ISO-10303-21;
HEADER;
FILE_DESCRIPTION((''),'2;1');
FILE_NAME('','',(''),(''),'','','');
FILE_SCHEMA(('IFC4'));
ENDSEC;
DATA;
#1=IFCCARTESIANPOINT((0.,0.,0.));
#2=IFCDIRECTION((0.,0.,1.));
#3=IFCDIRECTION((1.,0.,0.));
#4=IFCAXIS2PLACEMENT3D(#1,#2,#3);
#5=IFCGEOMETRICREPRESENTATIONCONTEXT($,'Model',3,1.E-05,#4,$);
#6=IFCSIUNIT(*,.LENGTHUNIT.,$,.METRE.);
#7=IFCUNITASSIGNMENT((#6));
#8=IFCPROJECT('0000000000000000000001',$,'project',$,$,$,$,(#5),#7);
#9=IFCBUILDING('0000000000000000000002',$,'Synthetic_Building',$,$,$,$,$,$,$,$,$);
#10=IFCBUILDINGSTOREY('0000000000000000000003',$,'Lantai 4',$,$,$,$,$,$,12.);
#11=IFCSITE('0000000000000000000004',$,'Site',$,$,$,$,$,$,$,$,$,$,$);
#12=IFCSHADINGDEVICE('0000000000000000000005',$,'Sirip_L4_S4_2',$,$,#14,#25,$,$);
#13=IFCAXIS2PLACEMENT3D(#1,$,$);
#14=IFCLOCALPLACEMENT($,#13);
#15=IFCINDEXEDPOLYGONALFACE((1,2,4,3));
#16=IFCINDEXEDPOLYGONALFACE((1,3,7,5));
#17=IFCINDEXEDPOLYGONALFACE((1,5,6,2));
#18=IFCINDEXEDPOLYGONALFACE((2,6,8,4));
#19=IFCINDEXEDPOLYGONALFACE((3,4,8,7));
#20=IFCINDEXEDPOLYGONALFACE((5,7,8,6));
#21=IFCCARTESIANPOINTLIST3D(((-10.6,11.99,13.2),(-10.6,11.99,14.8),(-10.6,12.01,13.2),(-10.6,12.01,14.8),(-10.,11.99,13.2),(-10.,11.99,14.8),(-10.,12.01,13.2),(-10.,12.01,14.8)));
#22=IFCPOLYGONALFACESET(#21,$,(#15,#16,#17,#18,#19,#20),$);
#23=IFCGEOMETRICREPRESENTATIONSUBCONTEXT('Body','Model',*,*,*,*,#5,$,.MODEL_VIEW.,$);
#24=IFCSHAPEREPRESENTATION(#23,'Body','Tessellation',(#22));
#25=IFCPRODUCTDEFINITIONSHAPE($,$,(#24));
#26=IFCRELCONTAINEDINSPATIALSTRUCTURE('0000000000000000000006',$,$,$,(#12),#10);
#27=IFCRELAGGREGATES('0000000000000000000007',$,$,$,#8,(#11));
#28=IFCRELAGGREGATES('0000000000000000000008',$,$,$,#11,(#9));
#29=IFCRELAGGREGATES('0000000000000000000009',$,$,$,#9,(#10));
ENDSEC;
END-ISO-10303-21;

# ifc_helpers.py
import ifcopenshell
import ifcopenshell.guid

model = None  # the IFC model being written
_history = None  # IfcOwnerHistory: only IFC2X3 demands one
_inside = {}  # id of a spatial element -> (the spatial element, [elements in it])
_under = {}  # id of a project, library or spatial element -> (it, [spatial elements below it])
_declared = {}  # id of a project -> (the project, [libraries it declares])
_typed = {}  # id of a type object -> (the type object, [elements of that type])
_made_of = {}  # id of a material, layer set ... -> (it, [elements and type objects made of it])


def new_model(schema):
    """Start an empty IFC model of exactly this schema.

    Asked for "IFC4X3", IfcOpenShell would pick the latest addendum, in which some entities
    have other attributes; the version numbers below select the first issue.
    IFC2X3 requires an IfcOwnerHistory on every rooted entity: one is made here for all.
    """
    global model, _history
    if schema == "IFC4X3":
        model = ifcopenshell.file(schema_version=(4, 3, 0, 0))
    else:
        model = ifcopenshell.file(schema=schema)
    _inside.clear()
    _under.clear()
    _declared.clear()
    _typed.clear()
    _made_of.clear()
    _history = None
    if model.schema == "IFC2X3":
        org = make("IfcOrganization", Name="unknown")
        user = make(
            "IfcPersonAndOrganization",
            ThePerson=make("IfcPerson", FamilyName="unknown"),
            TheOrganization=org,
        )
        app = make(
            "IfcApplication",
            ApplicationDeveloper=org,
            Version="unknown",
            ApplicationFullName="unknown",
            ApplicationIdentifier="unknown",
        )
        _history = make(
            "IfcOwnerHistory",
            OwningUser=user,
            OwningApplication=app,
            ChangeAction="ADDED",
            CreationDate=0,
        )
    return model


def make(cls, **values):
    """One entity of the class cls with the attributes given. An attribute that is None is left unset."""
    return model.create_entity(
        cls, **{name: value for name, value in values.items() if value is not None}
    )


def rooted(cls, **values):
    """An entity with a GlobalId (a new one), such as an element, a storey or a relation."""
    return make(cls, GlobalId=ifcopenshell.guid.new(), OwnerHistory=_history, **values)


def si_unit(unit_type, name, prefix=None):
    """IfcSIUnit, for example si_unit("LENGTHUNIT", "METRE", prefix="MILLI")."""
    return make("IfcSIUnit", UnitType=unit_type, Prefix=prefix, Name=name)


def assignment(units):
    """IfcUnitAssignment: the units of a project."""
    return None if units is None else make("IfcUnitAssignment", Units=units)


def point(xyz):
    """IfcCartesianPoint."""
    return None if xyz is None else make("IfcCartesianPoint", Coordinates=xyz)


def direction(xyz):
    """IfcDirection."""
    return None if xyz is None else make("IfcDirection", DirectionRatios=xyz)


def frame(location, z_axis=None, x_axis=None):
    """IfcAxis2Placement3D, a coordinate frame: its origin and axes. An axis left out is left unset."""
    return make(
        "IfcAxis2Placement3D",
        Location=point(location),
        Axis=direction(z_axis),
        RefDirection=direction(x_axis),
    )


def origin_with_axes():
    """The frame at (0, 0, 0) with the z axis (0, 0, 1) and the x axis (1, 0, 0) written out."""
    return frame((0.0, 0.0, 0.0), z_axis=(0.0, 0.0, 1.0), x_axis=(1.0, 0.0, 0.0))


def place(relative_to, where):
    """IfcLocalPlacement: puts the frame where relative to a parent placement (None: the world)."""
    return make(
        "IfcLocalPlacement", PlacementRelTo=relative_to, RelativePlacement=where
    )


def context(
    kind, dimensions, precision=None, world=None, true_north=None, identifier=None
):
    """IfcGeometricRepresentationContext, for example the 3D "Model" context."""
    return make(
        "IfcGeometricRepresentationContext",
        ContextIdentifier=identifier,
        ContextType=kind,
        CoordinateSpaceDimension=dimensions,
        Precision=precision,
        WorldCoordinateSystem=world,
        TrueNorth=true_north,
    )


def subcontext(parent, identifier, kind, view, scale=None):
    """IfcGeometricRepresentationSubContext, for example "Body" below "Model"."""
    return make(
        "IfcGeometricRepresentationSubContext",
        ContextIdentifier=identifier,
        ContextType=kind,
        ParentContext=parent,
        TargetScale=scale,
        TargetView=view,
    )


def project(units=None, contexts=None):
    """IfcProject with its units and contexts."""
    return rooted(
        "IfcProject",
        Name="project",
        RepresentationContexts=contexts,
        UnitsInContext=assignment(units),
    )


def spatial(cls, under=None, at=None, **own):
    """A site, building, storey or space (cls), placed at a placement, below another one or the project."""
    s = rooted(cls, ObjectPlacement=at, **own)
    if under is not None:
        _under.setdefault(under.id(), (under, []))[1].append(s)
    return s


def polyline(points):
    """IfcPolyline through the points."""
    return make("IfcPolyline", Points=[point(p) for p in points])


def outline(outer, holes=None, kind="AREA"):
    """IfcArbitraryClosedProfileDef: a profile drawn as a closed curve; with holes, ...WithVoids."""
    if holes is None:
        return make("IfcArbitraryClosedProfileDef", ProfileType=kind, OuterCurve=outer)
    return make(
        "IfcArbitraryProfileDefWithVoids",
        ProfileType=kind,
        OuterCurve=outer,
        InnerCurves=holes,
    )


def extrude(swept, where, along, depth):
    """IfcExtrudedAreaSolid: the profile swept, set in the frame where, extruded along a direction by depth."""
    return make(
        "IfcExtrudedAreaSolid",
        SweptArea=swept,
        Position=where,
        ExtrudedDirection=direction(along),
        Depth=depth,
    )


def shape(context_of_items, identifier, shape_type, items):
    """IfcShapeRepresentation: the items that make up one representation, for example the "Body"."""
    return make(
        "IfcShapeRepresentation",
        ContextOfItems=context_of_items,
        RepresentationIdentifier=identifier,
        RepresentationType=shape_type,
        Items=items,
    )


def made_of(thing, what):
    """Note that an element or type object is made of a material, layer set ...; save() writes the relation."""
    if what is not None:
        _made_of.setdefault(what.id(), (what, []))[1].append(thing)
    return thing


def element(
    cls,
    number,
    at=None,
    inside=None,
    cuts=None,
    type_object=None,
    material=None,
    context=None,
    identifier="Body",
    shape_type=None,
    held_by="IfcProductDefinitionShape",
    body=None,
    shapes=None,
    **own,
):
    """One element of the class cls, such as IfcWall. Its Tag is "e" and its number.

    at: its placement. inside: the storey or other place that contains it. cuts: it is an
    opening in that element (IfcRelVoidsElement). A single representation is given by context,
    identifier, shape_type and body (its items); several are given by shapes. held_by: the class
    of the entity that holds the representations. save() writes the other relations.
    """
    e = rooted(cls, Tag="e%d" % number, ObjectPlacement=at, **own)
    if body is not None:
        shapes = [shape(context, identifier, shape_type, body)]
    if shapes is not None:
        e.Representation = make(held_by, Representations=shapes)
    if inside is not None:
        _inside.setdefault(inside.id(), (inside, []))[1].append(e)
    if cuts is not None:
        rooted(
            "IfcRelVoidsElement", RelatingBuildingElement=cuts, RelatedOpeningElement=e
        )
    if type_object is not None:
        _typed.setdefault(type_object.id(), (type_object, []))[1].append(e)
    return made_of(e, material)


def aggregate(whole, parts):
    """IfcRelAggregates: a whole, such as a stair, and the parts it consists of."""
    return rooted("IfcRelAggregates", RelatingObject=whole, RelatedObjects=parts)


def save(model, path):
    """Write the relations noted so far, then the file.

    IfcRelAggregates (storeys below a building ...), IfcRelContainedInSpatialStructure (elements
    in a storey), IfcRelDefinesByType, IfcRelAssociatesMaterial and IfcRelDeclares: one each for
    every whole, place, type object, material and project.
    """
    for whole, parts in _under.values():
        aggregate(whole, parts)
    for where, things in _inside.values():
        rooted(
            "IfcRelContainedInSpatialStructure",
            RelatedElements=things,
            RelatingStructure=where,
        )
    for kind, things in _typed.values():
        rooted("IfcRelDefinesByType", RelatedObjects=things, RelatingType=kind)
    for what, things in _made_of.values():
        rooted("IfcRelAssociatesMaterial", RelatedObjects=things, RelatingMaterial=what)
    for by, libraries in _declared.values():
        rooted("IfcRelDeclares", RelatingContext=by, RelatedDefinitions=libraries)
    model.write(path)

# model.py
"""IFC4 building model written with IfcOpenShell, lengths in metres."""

from ifc_helpers import new_model, si_unit, frame, origin_with_axes, place, context, subcontext, project, spatial, polyline, outline, extrude, element, save


model = new_model("IFC4")

# Units and contexts
model_context = context("Model", 3, precision=1e-05, world=origin_with_axes())
body_context = subcontext(model_context, "Body", "Model", "MODEL_VIEW")
ifc_project = project(units=[si_unit("LENGTHUNIT", "METRE")], contexts=[model_context])

# Site, building, storey
site = spatial("IfcSite", under=ifc_project, Name="Site")
building = spatial("IfcBuilding", under=site, Name="Synthetic_Building")
storey = spatial("IfcBuildingStorey", under=building, Name="Lantai 4", Elevation=12.0)

# Shading device
shading_device_1_placement = place(None, origin_with_axes())
element("IfcShadingDevice", 1, at=shading_device_1_placement, inside=storey, Name="Sirip_L4_S4_2", context=body_context, shape_type="SweptSolid", body=[
    extrude(outline(polyline([(-10.0, 12.01), (-10.0, 11.99), (-10.6, 11.99), (-10.6, 12.01), (-10.0, 12.01)])), frame((0.0, 0.0, 13.2), z_axis=(0.0, 0.0, 1.0), x_axis=(1.0, 0.0, 0.0)), (0.0, 0.0, 1.0), 1.6),
])

save(model, "model.ifc")
